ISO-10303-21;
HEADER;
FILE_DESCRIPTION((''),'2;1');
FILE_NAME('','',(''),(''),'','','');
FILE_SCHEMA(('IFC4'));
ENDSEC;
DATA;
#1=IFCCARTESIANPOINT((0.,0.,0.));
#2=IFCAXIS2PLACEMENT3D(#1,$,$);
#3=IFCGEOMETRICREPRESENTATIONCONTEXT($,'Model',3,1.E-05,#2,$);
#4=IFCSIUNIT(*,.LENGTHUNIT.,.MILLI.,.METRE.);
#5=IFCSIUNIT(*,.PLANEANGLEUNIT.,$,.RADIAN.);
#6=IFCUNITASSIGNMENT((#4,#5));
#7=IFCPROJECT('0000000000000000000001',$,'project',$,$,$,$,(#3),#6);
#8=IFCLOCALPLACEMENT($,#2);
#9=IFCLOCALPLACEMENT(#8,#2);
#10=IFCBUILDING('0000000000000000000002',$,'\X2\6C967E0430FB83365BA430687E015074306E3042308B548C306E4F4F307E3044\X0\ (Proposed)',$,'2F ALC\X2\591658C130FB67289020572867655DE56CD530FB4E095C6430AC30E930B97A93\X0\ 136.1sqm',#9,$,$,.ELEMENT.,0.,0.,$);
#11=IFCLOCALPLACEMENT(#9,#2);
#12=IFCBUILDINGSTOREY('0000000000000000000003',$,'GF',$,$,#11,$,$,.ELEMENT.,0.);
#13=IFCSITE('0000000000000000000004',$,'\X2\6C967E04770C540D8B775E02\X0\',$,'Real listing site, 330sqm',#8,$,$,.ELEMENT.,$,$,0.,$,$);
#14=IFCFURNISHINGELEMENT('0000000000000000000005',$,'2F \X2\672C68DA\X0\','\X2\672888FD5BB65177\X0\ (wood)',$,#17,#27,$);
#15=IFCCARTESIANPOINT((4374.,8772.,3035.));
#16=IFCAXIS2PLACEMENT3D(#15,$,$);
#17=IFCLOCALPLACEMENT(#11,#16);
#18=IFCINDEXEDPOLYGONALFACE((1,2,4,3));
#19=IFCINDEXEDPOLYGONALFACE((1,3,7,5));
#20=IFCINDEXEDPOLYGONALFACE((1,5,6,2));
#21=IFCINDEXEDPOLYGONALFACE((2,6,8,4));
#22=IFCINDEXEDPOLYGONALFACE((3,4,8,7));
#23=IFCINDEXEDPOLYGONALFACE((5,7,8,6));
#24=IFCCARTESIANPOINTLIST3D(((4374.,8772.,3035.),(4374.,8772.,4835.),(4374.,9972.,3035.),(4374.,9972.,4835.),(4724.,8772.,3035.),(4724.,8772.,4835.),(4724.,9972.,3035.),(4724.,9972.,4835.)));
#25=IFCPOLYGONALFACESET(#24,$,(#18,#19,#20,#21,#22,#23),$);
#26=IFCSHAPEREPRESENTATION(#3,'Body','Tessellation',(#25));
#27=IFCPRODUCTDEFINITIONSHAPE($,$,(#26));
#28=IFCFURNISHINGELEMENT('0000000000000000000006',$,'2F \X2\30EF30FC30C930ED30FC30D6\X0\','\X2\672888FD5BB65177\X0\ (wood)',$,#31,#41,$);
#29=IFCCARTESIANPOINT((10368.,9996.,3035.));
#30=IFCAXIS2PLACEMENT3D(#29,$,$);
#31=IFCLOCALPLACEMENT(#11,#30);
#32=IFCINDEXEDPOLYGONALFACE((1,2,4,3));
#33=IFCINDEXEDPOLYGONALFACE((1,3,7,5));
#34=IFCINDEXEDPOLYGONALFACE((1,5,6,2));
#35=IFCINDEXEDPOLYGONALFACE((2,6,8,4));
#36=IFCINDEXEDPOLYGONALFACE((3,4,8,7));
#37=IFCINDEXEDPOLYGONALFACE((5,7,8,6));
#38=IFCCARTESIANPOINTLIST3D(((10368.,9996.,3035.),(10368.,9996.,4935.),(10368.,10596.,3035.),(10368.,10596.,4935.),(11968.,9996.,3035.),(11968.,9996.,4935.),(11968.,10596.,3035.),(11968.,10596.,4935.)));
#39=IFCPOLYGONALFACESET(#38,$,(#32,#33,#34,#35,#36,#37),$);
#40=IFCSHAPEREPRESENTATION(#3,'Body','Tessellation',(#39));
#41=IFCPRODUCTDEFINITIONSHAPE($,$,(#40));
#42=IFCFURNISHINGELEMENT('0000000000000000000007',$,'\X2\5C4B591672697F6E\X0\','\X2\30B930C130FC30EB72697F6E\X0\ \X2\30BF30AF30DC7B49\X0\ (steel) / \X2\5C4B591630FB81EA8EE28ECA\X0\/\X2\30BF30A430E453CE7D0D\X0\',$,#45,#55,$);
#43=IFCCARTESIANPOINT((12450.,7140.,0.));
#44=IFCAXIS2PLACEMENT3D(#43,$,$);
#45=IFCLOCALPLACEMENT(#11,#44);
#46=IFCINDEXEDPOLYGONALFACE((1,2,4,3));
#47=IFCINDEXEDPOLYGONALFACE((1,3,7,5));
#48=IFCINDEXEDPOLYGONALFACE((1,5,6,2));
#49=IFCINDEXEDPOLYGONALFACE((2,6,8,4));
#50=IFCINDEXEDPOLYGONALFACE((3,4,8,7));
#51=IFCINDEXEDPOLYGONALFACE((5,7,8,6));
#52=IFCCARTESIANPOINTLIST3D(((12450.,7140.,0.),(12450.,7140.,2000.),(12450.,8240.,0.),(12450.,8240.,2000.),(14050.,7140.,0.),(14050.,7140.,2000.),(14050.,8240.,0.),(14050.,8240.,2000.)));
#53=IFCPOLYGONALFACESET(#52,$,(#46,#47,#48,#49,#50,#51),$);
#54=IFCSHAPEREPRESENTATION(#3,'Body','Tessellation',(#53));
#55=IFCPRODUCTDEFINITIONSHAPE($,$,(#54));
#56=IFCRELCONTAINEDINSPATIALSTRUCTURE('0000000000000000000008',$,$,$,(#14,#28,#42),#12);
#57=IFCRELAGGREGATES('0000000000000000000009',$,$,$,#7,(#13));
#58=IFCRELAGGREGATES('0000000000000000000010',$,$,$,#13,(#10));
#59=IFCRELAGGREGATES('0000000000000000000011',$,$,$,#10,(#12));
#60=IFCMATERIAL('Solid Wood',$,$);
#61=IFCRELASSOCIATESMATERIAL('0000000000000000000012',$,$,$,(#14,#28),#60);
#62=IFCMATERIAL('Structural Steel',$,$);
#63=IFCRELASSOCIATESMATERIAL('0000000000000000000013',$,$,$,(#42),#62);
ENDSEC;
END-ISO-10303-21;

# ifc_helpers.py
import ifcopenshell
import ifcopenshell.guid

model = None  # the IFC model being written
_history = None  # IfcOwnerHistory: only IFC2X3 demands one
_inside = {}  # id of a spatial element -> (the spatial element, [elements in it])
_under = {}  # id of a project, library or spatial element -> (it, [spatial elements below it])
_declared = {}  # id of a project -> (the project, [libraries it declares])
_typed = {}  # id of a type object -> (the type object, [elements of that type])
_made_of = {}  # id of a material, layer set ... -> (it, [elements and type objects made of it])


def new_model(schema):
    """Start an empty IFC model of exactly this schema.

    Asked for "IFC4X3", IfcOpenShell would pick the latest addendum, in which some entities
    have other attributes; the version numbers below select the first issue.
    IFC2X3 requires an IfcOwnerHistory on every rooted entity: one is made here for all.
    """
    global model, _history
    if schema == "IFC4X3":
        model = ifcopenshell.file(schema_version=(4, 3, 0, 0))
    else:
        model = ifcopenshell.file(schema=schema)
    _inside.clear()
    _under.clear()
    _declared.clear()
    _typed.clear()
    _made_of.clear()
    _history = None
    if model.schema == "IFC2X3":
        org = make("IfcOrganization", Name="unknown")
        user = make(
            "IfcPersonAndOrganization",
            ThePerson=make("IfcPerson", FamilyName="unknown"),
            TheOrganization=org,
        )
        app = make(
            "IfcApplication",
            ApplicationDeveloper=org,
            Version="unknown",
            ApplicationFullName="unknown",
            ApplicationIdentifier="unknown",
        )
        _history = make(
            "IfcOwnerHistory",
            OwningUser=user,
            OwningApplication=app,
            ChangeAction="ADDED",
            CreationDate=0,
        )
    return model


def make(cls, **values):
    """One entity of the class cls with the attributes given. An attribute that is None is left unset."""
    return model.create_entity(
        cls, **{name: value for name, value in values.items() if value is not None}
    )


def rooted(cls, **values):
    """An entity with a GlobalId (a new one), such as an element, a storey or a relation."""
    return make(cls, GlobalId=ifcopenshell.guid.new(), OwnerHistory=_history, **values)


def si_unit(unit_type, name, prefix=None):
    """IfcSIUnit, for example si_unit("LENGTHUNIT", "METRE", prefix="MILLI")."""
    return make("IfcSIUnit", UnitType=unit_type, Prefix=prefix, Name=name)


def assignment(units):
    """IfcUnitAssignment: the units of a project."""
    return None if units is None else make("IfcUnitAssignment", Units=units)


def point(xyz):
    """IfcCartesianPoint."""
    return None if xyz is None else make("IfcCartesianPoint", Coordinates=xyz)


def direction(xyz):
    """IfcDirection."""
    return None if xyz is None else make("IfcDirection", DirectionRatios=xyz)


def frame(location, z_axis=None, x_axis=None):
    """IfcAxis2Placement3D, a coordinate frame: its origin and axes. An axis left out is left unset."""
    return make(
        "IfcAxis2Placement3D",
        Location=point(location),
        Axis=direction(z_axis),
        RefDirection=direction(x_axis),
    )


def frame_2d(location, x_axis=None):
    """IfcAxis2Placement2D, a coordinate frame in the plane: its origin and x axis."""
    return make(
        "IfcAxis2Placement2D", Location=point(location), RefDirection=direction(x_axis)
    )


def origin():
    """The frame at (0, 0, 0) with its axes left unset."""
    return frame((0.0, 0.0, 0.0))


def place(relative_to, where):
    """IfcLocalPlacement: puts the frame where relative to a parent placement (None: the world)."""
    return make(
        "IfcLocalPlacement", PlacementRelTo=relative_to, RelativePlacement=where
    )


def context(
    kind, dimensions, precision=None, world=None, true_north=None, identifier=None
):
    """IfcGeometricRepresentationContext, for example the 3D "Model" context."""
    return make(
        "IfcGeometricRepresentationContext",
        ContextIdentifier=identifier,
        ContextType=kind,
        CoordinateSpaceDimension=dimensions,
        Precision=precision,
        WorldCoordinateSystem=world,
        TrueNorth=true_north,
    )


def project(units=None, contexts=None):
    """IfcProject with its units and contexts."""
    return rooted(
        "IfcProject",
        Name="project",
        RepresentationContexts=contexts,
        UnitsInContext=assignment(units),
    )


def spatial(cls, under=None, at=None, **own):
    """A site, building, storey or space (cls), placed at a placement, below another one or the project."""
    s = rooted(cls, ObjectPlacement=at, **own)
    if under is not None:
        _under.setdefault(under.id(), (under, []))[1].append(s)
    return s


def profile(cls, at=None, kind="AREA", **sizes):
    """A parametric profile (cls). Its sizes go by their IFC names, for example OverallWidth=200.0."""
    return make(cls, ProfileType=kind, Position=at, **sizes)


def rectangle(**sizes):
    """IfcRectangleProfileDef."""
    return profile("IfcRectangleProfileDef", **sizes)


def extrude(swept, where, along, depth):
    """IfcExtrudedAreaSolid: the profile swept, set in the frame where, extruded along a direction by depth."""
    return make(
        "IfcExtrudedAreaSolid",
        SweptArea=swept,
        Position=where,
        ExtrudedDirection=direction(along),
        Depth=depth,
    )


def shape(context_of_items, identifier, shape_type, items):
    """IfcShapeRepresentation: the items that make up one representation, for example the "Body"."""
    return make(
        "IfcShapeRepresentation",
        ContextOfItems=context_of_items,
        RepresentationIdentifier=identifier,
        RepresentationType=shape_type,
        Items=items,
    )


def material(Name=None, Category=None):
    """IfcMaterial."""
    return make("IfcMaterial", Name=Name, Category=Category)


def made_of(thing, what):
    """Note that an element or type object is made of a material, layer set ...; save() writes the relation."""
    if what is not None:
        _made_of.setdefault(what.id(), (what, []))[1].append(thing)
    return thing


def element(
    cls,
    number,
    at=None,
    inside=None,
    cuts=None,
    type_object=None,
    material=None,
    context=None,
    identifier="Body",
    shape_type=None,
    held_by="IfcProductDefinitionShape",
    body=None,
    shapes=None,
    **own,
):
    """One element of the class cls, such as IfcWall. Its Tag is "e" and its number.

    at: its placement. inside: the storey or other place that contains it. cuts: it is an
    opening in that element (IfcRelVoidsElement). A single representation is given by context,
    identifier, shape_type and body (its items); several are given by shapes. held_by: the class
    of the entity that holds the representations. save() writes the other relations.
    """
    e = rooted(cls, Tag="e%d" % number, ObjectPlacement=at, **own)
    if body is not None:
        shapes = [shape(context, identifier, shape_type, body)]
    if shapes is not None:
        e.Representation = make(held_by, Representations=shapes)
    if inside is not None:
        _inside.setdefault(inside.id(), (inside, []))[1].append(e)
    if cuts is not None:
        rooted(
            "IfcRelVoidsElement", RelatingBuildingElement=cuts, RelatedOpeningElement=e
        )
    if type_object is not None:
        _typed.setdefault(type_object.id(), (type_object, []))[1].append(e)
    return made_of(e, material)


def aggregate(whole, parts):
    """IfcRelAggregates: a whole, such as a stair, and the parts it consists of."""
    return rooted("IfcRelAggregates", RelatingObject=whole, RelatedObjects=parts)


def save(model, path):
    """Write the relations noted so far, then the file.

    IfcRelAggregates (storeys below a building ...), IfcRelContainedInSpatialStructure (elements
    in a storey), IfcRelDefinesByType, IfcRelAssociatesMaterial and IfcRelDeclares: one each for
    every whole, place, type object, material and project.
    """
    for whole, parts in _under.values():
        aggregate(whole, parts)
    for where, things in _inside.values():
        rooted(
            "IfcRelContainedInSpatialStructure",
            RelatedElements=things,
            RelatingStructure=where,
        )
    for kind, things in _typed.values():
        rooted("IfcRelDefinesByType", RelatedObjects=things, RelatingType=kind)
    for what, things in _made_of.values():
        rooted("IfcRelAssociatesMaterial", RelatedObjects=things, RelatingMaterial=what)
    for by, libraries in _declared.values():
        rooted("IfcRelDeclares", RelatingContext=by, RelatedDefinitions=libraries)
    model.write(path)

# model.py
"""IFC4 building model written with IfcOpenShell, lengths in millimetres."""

from ifc_helpers import new_model, si_unit, frame, frame_2d, origin, place, context, project, spatial, rectangle, extrude, material, element, save


model = new_model("IFC4")

# Units and contexts
model_context = context("Model", 3, precision=1e-05, world=origin())
ifc_project = project(units=[si_unit("LENGTHUNIT", "METRE", prefix="MILLI"), si_unit("PLANEANGLEUNIT", "RADIAN")], contexts=[model_context])

# Site, building, storey
site_placement = place(None, origin())
site = spatial("IfcSite", under=ifc_project, at=site_placement, Name="沖縄県名護市", ObjectType="Real listing site, 330sqm", CompositionType="ELEMENT", RefElevation=0.0)
building_placement = place(site_placement, origin())
building = spatial("IfcBuilding", under=site, at=building_placement, Name="沖縄・茶室と縁側のある和の住まい (Proposed)", ObjectType="2F ALC外壁・木造在来工法・三層ガラス窓 136.1sqm", CompositionType="ELEMENT", ElevationOfRefHeight=0.0, ElevationOfTerrain=0.0)
storey_placement = place(building_placement, origin())
storey = spatial("IfcBuildingStorey", under=building, at=storey_placement, Name="GF", CompositionType="ELEMENT", Elevation=0.0)

# Shared definitions
ifc_material_1 = material(Name="Solid Wood")

# Shared definitions
ifc_material_2 = material(Name="Structural Steel")

# Furnishing elements
furnishing_1_placement = place(storey_placement, frame((4374.0, 8772.0, 3035.0)))
element("IfcFurnishingElement", 1, at=furnishing_1_placement, inside=storey, material=ifc_material_1, Name="2F 本棚", Description="木製家具 (wood)", context=model_context, shape_type="SweptSolid", body=[
    extrude(rectangle(XDim=350.0, YDim=1200.0, at=frame_2d((175.0, 600.0))), frame((4374.0, 8772.0, 3035.0)), (0.0, 0.0, 1.0), 1800.0),
])
furnishing_2_placement = place(storey_placement, frame((10368.0, 9996.0, 3035.0)))
element("IfcFurnishingElement", 2, at=furnishing_2_placement, inside=storey, material=ifc_material_1, Name="2F ワードローブ", Description="木製家具 (wood)", context=model_context, shape_type="SweptSolid", body=[
    extrude(rectangle(XDim=1600.0, YDim=600.0, at=frame_2d((800.0, 300.0))), frame((10368.0, 9996.0, 3035.0)), (0.0, 0.0, 1.0), 1900.0),
])
furnishing_3_placement = place(storey_placement, frame((12450.0, 7140.0, 0.0)))
element("IfcFurnishingElement", 3, at=furnishing_3_placement, inside=storey, material=ifc_material_2, Name="屋外物置", Description="スチール物置 タクボ等 (steel) / 屋外・自転車/タイヤ収納", context=model_context, shape_type="SweptSolid", body=[
    extrude(rectangle(XDim=1600.0, YDim=1100.0, at=frame_2d((800.0, 550.0))), frame((12450.0, 7140.0, 0.0)), (0.0, 0.0, 1.0), 2000.0),
])

save(model, "model.ifc")
